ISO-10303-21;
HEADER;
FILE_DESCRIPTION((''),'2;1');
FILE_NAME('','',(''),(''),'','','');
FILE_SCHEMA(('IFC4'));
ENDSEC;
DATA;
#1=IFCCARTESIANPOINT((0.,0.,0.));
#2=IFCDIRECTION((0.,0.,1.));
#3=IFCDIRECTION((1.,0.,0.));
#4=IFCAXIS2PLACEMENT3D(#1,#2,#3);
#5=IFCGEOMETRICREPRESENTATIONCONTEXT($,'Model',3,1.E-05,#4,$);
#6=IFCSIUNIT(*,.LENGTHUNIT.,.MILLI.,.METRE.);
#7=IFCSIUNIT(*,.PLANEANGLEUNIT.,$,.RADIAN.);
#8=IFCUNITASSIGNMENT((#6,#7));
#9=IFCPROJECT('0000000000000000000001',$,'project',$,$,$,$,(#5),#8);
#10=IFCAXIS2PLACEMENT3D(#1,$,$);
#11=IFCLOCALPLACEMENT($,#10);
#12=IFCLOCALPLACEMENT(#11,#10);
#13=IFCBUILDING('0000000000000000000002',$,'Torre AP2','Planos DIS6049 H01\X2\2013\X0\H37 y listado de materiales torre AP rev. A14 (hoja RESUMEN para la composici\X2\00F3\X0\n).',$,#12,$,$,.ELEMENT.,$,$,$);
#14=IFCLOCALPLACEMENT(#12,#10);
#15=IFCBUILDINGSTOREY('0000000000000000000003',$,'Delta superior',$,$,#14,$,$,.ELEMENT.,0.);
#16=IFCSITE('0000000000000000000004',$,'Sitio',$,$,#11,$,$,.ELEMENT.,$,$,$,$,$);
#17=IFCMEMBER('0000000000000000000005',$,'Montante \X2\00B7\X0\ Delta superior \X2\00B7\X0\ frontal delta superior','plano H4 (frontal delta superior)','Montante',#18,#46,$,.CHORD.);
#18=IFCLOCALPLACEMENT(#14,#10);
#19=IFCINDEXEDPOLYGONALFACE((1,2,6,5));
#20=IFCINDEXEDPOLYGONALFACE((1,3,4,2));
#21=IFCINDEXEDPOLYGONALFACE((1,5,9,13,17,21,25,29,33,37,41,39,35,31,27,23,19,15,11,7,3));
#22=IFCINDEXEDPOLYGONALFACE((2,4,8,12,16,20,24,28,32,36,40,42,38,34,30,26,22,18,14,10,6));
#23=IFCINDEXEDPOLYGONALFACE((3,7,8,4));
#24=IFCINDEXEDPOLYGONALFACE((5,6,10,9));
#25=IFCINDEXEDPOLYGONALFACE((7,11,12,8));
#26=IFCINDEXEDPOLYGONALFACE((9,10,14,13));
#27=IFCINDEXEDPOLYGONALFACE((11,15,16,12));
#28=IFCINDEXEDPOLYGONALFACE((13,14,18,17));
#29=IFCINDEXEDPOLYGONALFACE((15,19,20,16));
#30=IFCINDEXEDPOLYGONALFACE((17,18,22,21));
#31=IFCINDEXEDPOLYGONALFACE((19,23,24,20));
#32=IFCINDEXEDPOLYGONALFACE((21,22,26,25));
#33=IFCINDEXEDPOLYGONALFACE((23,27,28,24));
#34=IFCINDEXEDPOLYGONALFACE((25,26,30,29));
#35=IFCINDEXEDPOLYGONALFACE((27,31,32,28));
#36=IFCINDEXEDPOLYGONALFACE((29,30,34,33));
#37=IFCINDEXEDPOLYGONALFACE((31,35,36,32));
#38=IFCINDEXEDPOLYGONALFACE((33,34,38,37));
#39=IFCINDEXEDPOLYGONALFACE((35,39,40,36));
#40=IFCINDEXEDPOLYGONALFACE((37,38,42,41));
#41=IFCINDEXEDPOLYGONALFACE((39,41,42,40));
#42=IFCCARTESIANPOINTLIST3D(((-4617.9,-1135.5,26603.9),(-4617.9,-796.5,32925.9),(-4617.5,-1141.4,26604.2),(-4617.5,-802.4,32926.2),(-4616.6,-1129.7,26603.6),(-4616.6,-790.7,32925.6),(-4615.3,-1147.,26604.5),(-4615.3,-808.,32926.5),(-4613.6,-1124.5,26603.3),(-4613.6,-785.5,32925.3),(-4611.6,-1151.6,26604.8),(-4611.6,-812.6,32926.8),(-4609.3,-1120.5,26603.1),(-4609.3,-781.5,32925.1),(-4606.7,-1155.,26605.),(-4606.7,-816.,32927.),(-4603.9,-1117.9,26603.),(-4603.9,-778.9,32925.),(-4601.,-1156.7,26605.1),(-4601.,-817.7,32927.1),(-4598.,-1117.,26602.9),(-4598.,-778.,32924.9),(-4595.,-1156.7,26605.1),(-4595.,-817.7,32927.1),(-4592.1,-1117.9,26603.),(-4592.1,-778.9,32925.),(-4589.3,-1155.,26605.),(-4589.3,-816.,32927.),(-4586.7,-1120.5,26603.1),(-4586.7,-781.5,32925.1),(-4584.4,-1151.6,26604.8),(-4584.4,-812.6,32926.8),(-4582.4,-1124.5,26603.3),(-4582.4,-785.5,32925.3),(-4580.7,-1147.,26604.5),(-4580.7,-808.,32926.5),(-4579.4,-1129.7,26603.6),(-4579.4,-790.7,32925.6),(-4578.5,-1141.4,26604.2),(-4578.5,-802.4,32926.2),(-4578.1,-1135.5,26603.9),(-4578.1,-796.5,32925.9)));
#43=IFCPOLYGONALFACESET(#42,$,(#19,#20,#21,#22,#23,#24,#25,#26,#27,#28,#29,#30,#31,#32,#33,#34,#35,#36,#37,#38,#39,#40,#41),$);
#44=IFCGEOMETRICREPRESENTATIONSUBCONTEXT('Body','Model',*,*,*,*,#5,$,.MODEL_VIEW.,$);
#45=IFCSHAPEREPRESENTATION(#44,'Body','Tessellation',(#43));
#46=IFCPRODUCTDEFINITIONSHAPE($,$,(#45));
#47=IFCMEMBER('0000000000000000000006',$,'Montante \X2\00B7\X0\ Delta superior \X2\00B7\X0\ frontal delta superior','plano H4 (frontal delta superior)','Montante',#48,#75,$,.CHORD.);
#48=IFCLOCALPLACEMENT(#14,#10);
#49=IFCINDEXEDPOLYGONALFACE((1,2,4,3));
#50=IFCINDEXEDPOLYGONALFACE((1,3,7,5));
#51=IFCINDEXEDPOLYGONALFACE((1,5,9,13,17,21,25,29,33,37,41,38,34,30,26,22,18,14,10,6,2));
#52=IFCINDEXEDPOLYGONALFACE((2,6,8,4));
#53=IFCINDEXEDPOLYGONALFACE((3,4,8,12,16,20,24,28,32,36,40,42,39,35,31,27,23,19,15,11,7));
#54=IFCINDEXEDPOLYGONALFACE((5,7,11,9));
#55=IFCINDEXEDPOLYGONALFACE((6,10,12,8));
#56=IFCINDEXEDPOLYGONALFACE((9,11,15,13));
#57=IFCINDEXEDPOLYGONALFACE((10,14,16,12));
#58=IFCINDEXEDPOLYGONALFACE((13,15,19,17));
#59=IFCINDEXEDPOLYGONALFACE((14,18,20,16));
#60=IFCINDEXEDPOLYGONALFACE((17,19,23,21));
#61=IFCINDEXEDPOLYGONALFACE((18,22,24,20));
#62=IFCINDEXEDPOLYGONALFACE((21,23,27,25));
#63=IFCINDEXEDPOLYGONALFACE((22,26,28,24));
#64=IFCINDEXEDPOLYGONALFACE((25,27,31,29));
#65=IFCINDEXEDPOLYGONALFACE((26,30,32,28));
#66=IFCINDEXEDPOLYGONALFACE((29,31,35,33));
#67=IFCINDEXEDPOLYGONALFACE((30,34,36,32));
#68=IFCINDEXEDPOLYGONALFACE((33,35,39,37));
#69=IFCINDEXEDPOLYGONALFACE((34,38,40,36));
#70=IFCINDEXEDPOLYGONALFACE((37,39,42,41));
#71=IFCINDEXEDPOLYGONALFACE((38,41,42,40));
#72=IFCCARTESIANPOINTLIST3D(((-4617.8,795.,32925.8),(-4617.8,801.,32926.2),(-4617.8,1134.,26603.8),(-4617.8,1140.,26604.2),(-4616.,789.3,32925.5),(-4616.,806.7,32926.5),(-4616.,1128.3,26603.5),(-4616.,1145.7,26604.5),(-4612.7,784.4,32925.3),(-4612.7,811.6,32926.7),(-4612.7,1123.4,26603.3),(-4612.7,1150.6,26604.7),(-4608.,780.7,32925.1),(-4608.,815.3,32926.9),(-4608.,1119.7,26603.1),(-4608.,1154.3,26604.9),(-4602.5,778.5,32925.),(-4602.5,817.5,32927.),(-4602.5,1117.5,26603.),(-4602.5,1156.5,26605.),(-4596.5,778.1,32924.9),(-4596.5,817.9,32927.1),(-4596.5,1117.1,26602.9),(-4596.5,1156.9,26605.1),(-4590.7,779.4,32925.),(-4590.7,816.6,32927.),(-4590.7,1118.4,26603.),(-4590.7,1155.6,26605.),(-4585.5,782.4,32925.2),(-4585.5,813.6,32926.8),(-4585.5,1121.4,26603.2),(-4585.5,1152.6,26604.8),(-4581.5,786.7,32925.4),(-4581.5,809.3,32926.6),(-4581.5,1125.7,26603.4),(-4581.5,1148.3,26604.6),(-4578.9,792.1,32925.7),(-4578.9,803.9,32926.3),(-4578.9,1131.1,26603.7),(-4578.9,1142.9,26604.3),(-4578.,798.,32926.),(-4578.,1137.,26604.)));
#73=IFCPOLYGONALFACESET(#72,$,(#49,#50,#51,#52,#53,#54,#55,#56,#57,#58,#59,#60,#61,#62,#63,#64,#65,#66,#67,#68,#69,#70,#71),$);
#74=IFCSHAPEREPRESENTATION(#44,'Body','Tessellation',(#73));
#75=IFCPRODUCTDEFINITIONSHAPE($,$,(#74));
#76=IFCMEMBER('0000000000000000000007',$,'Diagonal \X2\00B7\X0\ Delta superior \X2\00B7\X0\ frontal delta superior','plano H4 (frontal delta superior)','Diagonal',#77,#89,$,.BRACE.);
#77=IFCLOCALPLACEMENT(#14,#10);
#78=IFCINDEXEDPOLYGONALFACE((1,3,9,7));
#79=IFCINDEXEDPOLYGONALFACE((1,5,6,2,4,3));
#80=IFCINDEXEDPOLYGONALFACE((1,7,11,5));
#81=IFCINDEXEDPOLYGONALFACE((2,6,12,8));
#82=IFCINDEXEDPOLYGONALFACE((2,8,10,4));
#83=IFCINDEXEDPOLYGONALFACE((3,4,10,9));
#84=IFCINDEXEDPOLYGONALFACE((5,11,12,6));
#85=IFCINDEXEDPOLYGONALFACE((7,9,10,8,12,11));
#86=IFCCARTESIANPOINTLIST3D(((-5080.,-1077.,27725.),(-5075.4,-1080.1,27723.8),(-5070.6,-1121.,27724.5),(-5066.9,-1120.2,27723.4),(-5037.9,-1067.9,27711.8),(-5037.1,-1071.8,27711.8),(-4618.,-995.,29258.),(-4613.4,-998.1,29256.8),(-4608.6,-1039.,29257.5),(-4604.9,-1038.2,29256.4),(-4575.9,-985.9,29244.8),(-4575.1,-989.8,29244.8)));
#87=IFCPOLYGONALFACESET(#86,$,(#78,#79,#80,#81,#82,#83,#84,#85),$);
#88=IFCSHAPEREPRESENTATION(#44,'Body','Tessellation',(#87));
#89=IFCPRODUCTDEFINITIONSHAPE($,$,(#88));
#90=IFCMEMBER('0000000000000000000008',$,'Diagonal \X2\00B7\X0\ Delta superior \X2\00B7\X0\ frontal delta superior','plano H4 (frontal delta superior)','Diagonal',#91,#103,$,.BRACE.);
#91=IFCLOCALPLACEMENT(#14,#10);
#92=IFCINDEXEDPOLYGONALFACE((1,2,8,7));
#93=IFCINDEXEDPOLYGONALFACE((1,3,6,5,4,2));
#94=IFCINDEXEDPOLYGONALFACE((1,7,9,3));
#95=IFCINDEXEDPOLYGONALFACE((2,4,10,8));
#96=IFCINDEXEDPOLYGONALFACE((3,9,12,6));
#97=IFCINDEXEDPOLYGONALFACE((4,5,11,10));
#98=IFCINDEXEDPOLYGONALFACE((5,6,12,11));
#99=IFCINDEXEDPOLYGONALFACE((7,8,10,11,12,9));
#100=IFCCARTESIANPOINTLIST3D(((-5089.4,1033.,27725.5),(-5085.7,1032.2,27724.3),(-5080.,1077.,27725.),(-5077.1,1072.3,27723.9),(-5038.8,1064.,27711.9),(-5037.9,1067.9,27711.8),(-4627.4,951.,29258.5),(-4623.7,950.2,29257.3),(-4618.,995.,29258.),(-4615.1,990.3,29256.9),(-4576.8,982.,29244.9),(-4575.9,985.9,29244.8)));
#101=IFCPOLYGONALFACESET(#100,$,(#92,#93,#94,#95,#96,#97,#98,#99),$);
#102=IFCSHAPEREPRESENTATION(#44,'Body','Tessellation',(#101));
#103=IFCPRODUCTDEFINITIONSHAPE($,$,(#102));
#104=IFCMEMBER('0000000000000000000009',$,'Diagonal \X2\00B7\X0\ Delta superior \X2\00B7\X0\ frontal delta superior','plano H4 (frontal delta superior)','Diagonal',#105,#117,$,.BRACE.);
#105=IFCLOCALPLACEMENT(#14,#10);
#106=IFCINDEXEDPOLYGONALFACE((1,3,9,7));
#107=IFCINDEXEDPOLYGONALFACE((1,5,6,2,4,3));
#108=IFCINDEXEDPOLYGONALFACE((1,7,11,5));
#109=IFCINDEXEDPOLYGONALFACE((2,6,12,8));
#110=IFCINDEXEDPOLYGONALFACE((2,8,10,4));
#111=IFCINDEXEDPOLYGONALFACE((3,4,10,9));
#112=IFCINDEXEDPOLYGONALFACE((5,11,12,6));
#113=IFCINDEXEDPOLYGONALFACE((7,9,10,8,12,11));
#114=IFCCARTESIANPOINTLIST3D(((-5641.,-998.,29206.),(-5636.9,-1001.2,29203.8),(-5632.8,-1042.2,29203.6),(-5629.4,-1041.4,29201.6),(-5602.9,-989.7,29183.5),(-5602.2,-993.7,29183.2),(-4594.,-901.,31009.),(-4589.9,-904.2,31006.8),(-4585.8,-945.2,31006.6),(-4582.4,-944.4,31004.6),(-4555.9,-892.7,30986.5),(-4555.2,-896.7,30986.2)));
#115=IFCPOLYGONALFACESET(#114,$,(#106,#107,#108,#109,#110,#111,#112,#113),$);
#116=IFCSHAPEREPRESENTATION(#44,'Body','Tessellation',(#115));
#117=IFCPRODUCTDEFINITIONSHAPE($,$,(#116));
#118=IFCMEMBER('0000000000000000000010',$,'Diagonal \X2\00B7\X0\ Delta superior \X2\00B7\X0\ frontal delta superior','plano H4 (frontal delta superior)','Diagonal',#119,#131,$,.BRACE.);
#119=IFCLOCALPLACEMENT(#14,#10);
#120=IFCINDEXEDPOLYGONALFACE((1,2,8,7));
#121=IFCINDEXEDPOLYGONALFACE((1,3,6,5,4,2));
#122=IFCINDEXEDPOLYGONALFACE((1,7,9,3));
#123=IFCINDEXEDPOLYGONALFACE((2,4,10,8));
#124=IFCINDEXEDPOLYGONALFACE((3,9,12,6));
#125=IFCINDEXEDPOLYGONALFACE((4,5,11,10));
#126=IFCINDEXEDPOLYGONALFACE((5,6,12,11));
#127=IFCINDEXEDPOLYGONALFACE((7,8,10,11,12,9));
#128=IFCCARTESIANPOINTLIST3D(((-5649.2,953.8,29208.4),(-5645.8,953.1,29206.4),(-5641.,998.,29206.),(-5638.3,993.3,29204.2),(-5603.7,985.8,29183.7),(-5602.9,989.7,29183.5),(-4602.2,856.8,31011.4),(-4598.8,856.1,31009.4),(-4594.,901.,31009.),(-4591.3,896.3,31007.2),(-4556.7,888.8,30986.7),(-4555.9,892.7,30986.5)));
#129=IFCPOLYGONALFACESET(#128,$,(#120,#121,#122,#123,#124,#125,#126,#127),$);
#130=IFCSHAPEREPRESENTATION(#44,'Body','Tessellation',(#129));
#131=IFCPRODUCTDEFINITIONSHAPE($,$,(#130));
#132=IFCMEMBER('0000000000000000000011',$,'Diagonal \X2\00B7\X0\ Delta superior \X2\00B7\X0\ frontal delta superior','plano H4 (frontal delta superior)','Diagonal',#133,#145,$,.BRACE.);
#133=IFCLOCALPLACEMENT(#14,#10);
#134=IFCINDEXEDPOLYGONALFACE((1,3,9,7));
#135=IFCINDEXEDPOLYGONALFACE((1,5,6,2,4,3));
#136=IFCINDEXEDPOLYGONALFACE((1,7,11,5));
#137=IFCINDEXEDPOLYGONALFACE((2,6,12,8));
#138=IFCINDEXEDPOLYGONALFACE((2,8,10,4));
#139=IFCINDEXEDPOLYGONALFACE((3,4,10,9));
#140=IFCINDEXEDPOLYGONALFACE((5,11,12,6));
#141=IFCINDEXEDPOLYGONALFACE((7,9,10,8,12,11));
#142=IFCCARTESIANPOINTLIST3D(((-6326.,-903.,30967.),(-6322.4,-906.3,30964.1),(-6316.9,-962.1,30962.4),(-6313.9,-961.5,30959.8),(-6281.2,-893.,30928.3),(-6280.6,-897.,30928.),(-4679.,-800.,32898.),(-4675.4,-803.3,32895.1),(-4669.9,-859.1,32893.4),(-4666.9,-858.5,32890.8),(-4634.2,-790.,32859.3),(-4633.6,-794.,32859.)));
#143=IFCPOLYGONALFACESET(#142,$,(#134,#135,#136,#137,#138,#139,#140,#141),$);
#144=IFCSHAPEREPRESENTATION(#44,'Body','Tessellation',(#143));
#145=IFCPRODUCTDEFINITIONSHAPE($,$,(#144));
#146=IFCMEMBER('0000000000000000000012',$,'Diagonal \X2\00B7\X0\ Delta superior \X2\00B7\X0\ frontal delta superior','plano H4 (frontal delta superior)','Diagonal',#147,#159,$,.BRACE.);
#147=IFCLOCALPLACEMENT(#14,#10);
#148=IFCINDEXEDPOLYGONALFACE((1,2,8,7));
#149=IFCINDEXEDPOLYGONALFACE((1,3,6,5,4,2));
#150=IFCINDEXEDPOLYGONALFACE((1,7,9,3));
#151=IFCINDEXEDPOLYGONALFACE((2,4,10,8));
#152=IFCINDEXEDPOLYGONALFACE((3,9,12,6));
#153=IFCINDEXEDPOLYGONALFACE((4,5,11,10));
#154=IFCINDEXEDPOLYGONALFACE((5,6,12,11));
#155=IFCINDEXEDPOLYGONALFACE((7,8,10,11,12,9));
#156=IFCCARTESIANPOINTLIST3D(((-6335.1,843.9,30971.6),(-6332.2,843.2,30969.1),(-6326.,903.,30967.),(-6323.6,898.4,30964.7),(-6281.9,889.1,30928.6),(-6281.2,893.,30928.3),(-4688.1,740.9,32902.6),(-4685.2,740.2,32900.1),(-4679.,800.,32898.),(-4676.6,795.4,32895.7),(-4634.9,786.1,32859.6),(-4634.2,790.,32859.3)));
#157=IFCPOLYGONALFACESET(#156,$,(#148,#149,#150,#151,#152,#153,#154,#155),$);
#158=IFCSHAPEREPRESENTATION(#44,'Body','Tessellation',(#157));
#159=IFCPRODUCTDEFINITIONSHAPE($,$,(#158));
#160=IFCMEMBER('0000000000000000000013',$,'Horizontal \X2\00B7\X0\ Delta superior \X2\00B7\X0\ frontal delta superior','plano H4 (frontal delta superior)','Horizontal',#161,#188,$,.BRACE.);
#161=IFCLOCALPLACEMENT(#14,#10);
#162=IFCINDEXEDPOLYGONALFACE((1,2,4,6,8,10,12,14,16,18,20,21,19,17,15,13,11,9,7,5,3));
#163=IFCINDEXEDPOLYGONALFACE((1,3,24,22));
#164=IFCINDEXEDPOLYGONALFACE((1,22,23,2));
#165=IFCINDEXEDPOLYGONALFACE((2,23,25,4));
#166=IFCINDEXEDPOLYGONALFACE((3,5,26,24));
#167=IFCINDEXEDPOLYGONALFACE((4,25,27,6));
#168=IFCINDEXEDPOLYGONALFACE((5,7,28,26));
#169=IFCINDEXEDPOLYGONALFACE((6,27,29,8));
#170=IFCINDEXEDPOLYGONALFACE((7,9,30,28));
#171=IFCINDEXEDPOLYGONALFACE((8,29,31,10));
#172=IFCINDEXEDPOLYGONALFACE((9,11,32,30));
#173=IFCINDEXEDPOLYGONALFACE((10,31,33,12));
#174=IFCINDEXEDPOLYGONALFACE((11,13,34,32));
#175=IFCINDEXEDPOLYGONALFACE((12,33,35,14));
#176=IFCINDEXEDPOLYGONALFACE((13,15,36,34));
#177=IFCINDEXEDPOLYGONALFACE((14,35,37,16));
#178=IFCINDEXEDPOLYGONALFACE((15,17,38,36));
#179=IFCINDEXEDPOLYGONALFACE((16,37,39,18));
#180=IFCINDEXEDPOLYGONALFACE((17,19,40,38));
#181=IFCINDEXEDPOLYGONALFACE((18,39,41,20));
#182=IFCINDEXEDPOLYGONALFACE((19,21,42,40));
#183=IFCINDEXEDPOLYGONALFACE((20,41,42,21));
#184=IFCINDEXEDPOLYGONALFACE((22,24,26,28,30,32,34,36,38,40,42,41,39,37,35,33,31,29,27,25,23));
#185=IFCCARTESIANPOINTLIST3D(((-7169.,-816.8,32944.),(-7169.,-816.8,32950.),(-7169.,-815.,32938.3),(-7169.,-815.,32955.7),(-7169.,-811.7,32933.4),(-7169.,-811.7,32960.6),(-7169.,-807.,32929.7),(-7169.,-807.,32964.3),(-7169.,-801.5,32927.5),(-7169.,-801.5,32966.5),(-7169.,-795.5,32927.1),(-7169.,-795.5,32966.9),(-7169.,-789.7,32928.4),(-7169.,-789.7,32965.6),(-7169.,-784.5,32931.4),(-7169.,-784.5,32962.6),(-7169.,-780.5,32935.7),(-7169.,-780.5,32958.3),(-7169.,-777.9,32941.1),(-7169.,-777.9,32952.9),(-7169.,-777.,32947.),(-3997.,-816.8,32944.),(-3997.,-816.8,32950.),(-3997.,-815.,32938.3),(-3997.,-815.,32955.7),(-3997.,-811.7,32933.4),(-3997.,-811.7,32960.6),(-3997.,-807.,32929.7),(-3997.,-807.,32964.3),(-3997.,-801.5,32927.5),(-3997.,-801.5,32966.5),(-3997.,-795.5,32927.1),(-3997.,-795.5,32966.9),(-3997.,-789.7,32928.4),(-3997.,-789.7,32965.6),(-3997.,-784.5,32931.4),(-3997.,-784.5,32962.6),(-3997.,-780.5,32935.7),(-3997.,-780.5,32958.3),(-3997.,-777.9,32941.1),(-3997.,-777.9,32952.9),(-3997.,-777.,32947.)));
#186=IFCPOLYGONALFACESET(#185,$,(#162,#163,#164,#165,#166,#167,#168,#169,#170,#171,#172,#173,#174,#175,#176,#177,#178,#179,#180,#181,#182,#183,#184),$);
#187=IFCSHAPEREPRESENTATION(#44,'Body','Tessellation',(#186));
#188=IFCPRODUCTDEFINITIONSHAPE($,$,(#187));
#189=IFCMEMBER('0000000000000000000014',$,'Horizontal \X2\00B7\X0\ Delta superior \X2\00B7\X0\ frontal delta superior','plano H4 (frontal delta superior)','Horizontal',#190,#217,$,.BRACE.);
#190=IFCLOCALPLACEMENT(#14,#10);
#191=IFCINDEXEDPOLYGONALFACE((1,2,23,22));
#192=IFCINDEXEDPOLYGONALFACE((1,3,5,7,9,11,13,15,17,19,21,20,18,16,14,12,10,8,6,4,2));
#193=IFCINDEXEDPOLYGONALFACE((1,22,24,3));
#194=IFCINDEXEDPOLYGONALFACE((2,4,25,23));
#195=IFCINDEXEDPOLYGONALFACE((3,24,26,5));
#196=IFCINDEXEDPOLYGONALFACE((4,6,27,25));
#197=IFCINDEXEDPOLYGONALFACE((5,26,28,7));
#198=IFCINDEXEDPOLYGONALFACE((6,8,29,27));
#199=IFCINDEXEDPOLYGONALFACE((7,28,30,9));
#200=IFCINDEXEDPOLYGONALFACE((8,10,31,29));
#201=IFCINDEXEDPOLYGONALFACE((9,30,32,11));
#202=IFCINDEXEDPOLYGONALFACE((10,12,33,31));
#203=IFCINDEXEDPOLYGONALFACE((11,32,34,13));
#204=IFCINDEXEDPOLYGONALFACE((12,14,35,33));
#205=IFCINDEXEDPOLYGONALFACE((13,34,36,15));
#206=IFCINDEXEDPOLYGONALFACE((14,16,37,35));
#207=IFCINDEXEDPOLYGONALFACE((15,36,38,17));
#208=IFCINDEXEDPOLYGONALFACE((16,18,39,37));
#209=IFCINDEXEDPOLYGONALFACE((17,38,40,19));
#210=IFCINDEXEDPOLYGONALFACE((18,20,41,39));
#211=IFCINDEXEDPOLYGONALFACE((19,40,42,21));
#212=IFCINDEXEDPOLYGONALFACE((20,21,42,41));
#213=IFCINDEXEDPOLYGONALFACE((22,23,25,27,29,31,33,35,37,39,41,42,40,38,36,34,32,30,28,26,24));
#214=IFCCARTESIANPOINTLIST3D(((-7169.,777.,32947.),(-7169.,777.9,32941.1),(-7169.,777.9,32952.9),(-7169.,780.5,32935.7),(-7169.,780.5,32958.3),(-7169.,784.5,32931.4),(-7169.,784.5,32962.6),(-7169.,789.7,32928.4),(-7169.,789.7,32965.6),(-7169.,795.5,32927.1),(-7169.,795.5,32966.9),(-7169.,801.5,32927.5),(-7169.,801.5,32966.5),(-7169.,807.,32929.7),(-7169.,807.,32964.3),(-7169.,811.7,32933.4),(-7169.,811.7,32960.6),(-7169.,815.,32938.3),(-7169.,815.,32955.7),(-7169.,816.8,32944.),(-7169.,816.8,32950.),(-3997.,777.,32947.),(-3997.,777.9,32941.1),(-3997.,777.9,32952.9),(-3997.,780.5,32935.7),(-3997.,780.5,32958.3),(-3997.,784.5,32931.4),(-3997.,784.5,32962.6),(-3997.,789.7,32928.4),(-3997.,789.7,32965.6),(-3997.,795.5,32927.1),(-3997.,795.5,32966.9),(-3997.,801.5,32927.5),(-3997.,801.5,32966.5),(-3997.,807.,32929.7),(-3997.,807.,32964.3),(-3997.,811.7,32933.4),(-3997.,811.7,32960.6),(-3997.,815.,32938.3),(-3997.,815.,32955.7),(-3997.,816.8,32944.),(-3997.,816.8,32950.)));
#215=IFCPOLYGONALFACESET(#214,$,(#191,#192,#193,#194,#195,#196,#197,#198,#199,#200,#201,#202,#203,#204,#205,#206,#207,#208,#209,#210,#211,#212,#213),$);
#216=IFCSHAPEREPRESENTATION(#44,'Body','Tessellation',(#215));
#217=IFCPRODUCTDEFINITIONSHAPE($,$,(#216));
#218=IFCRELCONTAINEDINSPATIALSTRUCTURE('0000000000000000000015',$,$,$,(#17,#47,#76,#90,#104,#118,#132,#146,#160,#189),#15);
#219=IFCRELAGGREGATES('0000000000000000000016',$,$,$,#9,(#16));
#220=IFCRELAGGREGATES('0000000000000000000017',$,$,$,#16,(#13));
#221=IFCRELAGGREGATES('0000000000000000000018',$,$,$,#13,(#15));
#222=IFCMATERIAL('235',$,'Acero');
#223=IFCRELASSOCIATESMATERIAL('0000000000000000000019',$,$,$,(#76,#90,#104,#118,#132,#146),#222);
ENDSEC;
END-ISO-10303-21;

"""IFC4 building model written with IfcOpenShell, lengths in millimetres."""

from ifc_helpers import new_model, si_unit, frame, frame_2d, origin, origin_with_axes, place, context, subcontext, project, spatial, circle, l_section, extrude, material, element, save


model = new_model("IFC4")

# Units and contexts
model_context = context("Model", 3, precision=1e-05, world=origin_with_axes())
body_context = subcontext(model_context, "Body", "Model", "MODEL_VIEW")
ifc_project = project(units=[si_unit("LENGTHUNIT", "METRE", prefix="MILLI"), si_unit("PLANEANGLEUNIT", "RADIAN")], contexts=[model_context])

# Site, building, storey
site_placement = place(None, origin())
site = spatial("IfcSite", under=ifc_project, at=site_placement, Name="Sitio", CompositionType="ELEMENT")
building_placement = place(site_placement, origin())
building = spatial("IfcBuilding", under=site, at=building_placement, Name="Torre AP2", Description="Planos DIS6049 H01–H37 y listado de materiales torre AP rev. A14 (hoja RESUMEN para la composición).", CompositionType="ELEMENT")
storey_placement = place(building_placement, origin())
storey = spatial("IfcBuildingStorey", under=building, at=storey_placement, Name="Delta superior", CompositionType="ELEMENT", Elevation=0.0)

# Members
for number, where, z_axis, x_axis, name in (
    (1, (-4598.0, -798.0, 32926.0), (0.0, -0.053545, -0.998565), (0.0, 0.998565, -0.053545), "Montante · Delta superior · frontal delta superior"),
    (2, (-4598.0, 798.0, 32926.0), (0.0, 0.053545, -0.998565), (1.0, 0.0, 0.0), "Montante · Delta superior · frontal delta superior"),
):
    element("IfcMember", number, at=place(storey_placement, frame(where, z_axis=z_axis, x_axis=x_axis)), inside=storey, Name=name, Description="plano H4 (frontal delta superior)", ObjectType="Montante", PredefinedType="CHORD", context=body_context, shape_type="SweptSolid", body=[
        extrude(circle(Radius=20.0), None, (0.0, 0.0, 1.0), 6331.1),
    ])
ifc_material_1 = material(Name="235", Category="Acero")
for number, where, z_axis, x_axis, name in (
    (3, (-4618.0, -995.0, 29258.0), (-0.288173, -0.051148, -0.956211), (0.934509, 0.202848, -0.292483), "Diagonal · Delta superior · frontal delta superior"),
    (4, (-4618.0, 995.0, 29258.0), (-0.288173, 0.051148, -0.956211), (0.934509, -0.202848, -0.292483), "Diagonal · Delta superior · frontal delta superior"),
):
    element("IfcMember", number, at=place(storey_placement, frame(where, z_axis=z_axis, x_axis=x_axis)), inside=storey, material=ifc_material_1, Name=name, Description="plano H4 (frontal delta superior)", ObjectType="Diagonal", PredefinedType="BRACE", context=body_context, shape_type="SweptSolid", body=[
        extrude(l_section(Depth=45.0, Width=45.0, Thickness=4.0, at=frame_2d((22.5, 22.5))), None, (0.0, 0.0, 1.0), 1603.2),
    ])
for number, where, z_axis, x_axis, name in (
    (5, (-4594.0, -901.0, 31009.0), (-0.501628, -0.046474, -0.863834), (0.845685, 0.183933, -0.500984), "Diagonal · Delta superior · frontal delta superior"),
    (6, (-4594.0, 901.0, 31009.0), (-0.501628, 0.046474, -0.863834), (0.845685, -0.183933, -0.500984), "Diagonal · Delta superior · frontal delta superior"),
):
    element("IfcMember", number, at=place(storey_placement, frame(where, z_axis=z_axis, x_axis=x_axis)), inside=storey, material=ifc_material_1, Name=name, Description="plano H4 (frontal delta superior)", ObjectType="Diagonal", PredefinedType="BRACE", context=body_context, shape_type="SweptSolid", body=[
        extrude(l_section(Depth=45.0, Width=45.0, Thickness=4.0, at=frame_2d((22.5, 22.5))), None, (0.0, 0.0, 1.0), 2087.2),
    ])
for number, where, z_axis, x_axis, name in (
    (7, (-4679.0, -800.0, 32898.0), (-0.648406, -0.04055, -0.760214), (0.745871, 0.166153, -0.645035), "Diagonal · Delta superior · frontal delta superior"),
    (8, (-4679.0, 800.0, 32898.0), (-0.648406, 0.04055, -0.760214), (0.745871, -0.166153, -0.645035), "Diagonal · Delta superior · frontal delta superior"),
):
    element("IfcMember", number, at=place(storey_placement, frame(where, z_axis=z_axis, x_axis=x_axis)), inside=storey, material=ifc_material_1, Name=name, Description="plano H4 (frontal delta superior)", ObjectType="Diagonal", PredefinedType="BRACE", context=body_context, shape_type="SweptSolid", body=[
        extrude(l_section(Depth=60.0, Width=60.0, Thickness=4.0, at=frame_2d((30.0, 30.0))), None, (0.0, 0.0, 1.0), 2540.1),
    ])
for number, where, z_axis, x_axis, name in (
    (9, (-3997.0, -797.0, 32947.0), (-1.0, 0.0, 0.0), (0.0, 1.0, 0.0), "Horizontal · Delta superior · frontal delta superior"),
    (10, (-3997.0, 797.0, 32947.0), (-1.0, 0.0, 0.0), (0.0, -1.0, 0.0), "Horizontal · Delta superior · frontal delta superior"),
):
    element("IfcMember", number, at=place(storey_placement, frame(where, z_axis=z_axis, x_axis=x_axis)), inside=storey, Name=name, Description="plano H4 (frontal delta superior)", ObjectType="Horizontal", PredefinedType="BRACE", context=body_context, shape_type="SweptSolid", body=[
        extrude(circle(Radius=20.0), None, (0.0, 0.0, 1.0), 3172.0),
    ])

save(model, "model.ifc")
